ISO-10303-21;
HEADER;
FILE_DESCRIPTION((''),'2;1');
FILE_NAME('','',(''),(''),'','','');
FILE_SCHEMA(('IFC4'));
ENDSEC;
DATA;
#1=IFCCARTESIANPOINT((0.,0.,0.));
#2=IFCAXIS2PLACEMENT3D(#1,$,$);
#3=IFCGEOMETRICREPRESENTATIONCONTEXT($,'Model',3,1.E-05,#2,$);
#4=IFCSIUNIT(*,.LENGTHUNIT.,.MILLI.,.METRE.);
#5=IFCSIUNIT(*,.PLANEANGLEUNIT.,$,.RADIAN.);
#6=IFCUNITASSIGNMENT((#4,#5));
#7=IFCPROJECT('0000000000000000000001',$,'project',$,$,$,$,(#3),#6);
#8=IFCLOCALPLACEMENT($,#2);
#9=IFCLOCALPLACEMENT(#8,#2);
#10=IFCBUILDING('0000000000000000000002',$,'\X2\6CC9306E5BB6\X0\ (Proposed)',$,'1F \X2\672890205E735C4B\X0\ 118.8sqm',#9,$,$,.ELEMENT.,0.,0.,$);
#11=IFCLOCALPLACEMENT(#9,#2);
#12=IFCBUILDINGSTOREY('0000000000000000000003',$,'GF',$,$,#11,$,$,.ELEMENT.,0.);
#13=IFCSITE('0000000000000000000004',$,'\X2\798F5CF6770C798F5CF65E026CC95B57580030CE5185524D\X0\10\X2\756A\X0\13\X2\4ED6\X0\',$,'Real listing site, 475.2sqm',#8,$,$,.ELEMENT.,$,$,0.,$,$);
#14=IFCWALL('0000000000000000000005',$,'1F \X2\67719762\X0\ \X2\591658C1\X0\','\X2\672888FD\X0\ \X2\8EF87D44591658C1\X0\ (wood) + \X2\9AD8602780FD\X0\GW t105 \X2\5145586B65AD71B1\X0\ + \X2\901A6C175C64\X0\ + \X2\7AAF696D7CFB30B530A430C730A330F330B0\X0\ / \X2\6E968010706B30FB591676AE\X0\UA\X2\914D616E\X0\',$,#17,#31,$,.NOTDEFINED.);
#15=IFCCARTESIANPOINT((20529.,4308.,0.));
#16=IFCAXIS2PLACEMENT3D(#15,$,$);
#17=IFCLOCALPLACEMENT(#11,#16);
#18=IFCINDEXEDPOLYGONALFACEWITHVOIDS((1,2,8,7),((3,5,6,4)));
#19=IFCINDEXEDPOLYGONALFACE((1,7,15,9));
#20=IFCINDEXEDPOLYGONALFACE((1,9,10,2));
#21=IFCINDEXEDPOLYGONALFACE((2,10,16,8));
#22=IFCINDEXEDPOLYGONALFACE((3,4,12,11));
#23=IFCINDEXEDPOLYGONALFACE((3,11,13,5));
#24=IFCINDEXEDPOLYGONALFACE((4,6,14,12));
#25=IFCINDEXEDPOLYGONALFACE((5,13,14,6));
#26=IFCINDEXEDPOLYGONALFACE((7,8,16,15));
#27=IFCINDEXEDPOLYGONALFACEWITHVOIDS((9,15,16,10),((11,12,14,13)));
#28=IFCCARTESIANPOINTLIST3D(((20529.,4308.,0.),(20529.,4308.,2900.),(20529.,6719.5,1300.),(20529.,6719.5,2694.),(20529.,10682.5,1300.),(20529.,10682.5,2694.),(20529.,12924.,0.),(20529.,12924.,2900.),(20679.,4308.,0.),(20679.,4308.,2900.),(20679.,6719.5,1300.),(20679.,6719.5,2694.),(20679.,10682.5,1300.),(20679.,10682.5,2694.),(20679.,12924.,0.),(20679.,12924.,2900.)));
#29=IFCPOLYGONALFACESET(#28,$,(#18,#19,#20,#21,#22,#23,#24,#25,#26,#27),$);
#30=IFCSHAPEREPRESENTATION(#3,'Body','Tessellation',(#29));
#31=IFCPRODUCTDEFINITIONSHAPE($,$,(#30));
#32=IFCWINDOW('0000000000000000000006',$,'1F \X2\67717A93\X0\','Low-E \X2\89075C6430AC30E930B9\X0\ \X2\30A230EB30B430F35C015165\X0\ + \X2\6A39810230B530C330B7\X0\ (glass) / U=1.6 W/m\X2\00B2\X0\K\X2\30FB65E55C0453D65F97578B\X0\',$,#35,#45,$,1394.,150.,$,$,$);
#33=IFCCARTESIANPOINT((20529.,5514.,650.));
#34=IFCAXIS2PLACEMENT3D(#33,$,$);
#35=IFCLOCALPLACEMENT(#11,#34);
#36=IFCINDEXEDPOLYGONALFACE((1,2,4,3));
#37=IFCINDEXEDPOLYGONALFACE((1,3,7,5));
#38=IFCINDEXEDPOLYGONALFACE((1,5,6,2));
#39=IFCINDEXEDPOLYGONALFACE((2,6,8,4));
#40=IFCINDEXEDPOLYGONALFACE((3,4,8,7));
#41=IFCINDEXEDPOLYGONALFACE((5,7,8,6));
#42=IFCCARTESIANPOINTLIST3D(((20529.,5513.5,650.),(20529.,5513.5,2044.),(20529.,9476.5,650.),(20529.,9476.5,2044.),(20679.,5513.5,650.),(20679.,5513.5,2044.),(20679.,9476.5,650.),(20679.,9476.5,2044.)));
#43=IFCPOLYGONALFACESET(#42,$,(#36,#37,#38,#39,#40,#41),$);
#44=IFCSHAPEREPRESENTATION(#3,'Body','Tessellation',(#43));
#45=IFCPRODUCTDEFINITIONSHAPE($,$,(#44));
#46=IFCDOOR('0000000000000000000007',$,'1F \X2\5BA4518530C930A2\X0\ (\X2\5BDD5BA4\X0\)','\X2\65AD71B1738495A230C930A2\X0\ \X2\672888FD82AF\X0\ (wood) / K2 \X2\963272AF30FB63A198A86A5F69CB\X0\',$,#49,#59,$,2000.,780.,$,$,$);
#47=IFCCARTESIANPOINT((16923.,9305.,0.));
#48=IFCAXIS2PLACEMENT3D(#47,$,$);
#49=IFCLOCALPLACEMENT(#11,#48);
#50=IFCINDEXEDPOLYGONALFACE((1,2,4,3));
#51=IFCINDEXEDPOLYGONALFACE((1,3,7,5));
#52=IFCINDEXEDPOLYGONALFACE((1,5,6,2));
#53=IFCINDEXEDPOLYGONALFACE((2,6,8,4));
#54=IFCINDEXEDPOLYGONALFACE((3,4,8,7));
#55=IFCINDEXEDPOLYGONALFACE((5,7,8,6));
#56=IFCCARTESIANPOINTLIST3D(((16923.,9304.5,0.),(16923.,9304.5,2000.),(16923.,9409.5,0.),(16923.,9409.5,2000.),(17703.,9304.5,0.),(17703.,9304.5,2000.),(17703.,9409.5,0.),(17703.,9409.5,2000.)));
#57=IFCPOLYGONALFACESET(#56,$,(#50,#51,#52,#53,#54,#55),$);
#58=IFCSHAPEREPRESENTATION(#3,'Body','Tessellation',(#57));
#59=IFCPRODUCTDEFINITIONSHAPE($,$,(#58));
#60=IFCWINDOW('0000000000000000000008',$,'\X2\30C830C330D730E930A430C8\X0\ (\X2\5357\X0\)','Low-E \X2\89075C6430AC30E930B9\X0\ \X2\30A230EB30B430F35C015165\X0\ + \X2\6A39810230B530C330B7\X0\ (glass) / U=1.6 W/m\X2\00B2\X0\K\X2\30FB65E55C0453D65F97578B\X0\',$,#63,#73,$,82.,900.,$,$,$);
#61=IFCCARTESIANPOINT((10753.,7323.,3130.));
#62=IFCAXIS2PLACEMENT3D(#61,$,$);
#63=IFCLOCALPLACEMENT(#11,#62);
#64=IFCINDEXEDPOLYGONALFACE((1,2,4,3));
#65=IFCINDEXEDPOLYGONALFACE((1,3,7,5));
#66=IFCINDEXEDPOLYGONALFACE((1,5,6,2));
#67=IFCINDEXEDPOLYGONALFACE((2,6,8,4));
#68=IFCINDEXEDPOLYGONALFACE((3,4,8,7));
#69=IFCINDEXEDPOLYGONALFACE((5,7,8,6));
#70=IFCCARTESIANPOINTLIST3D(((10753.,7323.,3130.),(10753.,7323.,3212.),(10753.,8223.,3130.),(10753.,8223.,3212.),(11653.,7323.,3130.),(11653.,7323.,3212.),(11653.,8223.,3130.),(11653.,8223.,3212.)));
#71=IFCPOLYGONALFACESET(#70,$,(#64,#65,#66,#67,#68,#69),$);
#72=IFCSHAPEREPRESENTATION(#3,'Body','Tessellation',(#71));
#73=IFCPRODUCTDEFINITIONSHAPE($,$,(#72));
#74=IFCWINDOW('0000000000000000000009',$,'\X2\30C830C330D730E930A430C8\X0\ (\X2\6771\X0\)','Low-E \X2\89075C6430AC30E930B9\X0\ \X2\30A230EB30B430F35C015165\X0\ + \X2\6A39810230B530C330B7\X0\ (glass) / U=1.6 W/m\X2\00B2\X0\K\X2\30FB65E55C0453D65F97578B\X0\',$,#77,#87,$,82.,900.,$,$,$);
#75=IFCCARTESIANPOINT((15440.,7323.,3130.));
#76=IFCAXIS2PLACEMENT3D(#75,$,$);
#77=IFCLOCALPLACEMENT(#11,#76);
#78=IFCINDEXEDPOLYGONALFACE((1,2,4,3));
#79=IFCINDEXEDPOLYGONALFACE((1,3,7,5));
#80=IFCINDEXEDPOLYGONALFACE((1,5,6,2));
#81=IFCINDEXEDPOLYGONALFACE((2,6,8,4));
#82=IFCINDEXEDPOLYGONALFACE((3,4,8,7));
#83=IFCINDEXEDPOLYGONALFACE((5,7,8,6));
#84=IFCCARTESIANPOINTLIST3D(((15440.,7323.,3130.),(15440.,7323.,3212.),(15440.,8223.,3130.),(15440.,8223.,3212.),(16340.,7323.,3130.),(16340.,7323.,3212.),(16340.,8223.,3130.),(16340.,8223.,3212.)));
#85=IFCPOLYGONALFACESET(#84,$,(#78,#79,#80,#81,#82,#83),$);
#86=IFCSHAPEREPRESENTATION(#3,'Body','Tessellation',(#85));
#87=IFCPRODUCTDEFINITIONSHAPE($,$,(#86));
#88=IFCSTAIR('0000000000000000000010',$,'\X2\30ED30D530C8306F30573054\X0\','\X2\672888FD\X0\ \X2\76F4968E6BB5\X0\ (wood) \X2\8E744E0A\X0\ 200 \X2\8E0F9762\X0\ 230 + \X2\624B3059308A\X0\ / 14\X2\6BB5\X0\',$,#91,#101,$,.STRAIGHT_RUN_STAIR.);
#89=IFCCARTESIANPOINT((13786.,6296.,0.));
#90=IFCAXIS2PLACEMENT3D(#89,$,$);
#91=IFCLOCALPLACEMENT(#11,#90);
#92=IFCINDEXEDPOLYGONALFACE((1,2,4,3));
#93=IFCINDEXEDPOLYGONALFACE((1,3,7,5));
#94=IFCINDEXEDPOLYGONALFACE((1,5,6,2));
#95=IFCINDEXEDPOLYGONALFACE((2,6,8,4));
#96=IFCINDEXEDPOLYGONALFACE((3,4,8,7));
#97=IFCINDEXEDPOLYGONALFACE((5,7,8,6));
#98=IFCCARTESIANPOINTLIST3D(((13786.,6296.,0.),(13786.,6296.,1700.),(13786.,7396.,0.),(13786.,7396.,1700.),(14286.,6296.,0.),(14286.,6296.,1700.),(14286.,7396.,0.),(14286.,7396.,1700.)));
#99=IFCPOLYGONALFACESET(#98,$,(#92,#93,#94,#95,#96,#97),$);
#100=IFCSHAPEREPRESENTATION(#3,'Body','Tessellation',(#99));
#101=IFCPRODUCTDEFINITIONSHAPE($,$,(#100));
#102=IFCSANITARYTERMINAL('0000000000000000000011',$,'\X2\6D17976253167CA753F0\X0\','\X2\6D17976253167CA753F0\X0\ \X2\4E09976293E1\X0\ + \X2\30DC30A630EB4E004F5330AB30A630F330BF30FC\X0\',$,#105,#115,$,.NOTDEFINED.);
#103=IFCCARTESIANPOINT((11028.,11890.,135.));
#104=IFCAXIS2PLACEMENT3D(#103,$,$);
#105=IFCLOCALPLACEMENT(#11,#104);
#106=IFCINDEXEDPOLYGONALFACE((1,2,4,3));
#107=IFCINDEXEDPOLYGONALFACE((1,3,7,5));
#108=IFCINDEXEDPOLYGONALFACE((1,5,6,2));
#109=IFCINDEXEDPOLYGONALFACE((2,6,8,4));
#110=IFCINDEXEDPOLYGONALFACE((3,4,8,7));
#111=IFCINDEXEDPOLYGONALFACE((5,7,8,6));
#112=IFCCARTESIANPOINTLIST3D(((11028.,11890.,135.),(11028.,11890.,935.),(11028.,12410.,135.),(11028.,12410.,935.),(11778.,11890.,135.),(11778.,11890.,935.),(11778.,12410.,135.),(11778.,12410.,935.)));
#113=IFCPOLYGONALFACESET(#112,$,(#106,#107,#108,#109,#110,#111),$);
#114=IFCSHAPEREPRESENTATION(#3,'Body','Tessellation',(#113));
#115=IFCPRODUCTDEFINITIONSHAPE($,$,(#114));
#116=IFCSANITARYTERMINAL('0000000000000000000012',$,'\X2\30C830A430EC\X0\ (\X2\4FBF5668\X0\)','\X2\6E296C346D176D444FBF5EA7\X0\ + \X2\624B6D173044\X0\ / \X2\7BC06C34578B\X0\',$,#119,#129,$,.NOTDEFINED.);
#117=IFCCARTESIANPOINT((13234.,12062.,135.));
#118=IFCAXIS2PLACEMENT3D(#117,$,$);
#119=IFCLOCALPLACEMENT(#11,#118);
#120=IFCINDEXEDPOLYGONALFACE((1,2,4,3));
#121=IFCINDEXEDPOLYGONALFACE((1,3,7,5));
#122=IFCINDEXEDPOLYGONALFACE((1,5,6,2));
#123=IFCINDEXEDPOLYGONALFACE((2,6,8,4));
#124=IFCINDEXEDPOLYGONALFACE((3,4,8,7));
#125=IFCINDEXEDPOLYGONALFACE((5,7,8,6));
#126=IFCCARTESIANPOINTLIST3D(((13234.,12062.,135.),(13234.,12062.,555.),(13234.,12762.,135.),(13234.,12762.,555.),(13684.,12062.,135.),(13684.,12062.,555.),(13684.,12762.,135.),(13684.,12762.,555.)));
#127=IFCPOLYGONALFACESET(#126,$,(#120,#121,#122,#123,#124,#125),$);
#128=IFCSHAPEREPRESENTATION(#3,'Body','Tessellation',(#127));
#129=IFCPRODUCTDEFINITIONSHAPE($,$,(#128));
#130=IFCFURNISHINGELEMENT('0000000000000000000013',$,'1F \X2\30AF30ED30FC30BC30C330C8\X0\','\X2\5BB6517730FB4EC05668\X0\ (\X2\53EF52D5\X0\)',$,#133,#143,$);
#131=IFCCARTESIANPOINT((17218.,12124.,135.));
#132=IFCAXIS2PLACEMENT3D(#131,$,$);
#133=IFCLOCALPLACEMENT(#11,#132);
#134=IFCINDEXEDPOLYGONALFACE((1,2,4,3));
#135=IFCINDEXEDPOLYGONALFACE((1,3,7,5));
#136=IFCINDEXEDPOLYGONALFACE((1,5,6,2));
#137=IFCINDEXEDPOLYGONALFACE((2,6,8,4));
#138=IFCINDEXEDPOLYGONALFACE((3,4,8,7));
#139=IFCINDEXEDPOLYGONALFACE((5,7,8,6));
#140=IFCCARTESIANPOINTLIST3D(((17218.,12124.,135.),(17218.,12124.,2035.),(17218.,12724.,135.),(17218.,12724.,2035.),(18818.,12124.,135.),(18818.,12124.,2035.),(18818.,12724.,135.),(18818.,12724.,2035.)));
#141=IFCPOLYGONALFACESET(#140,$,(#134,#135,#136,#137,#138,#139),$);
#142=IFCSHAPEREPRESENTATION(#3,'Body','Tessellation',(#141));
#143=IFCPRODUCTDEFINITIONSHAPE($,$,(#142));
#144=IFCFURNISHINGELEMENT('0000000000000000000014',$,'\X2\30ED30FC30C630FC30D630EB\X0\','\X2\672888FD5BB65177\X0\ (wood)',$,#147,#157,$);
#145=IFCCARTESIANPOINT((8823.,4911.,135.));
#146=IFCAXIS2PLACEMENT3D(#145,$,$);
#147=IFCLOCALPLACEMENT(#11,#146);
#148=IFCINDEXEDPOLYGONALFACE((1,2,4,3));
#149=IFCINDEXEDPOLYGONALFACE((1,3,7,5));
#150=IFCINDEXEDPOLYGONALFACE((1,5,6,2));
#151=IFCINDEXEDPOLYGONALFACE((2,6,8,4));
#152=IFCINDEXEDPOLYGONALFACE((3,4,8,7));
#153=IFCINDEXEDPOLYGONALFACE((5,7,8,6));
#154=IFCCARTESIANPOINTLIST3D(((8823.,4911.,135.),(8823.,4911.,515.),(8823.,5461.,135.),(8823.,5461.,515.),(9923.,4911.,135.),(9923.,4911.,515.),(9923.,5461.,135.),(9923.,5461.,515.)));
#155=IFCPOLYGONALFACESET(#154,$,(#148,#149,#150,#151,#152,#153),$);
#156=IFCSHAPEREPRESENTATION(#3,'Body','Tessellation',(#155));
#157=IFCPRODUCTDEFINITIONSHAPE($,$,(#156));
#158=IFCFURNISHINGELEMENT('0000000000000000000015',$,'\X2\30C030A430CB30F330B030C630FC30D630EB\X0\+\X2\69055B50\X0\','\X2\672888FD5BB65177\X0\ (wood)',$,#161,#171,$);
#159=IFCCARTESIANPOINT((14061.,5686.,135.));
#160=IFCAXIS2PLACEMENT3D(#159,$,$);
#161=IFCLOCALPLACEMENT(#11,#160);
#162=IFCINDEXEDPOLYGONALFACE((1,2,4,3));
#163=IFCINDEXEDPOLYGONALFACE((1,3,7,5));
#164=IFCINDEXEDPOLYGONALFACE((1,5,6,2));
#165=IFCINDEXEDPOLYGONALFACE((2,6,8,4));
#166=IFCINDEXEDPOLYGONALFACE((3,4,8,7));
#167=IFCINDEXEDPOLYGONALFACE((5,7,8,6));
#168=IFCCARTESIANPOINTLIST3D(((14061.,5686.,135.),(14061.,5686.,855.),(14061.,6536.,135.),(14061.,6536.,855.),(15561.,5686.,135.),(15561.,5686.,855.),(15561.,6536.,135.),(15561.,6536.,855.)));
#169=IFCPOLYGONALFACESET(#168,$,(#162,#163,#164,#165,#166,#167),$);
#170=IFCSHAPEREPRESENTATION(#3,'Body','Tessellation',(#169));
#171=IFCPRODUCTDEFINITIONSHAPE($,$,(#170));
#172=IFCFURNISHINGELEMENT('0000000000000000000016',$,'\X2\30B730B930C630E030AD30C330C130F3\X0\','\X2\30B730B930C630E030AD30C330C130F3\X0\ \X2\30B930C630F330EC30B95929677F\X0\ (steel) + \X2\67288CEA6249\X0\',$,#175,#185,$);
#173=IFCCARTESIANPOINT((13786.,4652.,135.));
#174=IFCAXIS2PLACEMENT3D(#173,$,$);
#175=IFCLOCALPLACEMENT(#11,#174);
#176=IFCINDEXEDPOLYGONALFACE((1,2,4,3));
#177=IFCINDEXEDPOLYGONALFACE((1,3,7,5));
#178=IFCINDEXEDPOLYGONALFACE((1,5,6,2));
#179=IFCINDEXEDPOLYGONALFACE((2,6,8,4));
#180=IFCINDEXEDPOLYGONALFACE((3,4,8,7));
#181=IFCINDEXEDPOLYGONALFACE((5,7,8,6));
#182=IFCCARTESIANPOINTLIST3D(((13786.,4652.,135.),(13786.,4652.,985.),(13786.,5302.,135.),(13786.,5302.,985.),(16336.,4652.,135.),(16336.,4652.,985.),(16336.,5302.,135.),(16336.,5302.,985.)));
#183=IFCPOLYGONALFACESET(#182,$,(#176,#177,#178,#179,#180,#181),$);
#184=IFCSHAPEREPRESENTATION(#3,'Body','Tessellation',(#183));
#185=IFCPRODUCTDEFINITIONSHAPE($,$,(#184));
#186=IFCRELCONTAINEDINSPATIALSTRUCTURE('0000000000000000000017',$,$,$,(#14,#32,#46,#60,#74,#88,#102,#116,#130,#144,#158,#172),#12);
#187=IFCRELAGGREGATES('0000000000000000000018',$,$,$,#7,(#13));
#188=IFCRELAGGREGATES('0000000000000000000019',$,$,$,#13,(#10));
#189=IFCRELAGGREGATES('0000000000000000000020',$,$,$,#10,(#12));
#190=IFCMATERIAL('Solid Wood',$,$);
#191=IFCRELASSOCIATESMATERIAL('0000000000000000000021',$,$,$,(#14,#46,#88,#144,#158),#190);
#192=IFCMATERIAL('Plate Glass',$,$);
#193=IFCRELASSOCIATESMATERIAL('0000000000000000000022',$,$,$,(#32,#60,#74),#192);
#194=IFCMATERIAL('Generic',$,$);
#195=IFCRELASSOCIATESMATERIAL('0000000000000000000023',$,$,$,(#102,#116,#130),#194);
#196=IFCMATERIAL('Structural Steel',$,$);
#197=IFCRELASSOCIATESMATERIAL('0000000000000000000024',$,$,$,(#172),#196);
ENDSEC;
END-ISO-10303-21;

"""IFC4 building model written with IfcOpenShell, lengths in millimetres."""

from ifc_helpers import new_model, si_unit, frame, frame_2d, origin, place, context, project, spatial, rectangle, extrude, material, element, fill, save


model = new_model("IFC4")

# Units and contexts
model_context = context("Model", 3, precision=1e-05, world=origin())
ifc_project = project(units=[si_unit("LENGTHUNIT", "METRE", prefix="MILLI"), si_unit("PLANEANGLEUNIT", "RADIAN")], contexts=[model_context])

# Site, building, storey
site_placement = place(None, origin())
site = spatial("IfcSite", under=ifc_project, at=site_placement, Name="福島県福島市泉字堀ノ内前10番13他", ObjectType="Real listing site, 475.2sqm", CompositionType="ELEMENT", RefElevation=0.0)
building_placement = place(site_placement, origin())
building = spatial("IfcBuilding", under=site, at=building_placement, Name="泉の家 (Proposed)", ObjectType="1F 木造平屋 118.8sqm", CompositionType="ELEMENT", ElevationOfRefHeight=0.0, ElevationOfTerrain=0.0)
storey_placement = place(building_placement, origin())
storey = spatial("IfcBuildingStorey", under=building, at=storey_placement, Name="GF", CompositionType="ELEMENT", Elevation=0.0)

# Wall, opening, window
ifc_material_1 = material(Name="Solid Wood")
wall_1_placement = place(storey_placement, frame((20529.0, 4308.0, 0.0)))
wall_1 = element("IfcWall", 1, at=wall_1_placement, inside=storey, material=ifc_material_1, Name="1F 東面 外壁", Description="木製 軸組外壁 (wood) + 高性能GW t105 充填断熱 + 通気層 + 窯業系サイディング / 準耐火・外皮UA配慮", PredefinedType="NOTDEFINED", context=model_context, shape_type="SweptSolid", body=[
    extrude(rectangle(XDim=150.0, YDim=8616.0, at=frame_2d((75.0, 4308.0))), frame((20529.0, 4308.0, 0.0)), (0.0, 0.0, 1.0), 2900.0),
])
opening_placement = place(storey_placement, frame((20529.0, 5514.0, 650.0)))
opening = element("IfcOpeningElement", 2, at=opening_placement, cuts=wall_1, PredefinedType="NOTDEFINED", context=model_context, shape_type="SweptSolid", body=[
    extrude(rectangle(XDim=150.0, YDim=3963.0, at=frame_2d((75.0, 1981.0))), frame((20529.0, 5514.0, 650.0)), (0.0, 0.0, 1.0), 1394.0),
])
ifc_material_2 = material(Name="Plate Glass")
window_1_placement = place(storey_placement, frame((20529.0, 5514.0, 650.0)))
window_1 = element("IfcWindow", 3, at=window_1_placement, inside=storey, material=ifc_material_2, Name="1F 東窓", Description="Low-E 複層ガラス アルゴン封入 + 樹脂サッシ (glass) / U=1.6 W/m²K・日射取得型", OverallHeight=1394.0, OverallWidth=150.0, context=model_context, shape_type="SweptSolid", body=[
    extrude(rectangle(XDim=150.0, YDim=3963.0, at=frame_2d((75.0, 1981.0))), frame((20529.0, 5514.0, 650.0)), (0.0, 0.0, 1.0), 1394.0),
])
fill(opening, window_1)

# Door
door_placement = place(storey_placement, frame((16923.0, 9305.0, 0.0)))
element("IfcDoor", 4, at=door_placement, inside=storey, material=ifc_material_1, Name="1F 室内ドア (寝室)", Description="断熱玄関ドア 木製芯 (wood) / K2 防犯・採風機構", OverallHeight=2000.0, OverallWidth=780.0, context=model_context, shape_type="SweptSolid", body=[
    extrude(rectangle(XDim=780.0, YDim=105.0, at=frame_2d((390.0, 52.0))), frame((16923.0, 9305.0, 0.0)), (0.0, 0.0, 1.0), 2000.0),
])

# Windows
window_2_placement = place(storey_placement, frame((10753.0, 7323.0, 3130.0)))
element("IfcWindow", 5, at=window_2_placement, inside=storey, material=ifc_material_2, Name="トップライト (南)", Description="Low-E 複層ガラス アルゴン封入 + 樹脂サッシ (glass) / U=1.6 W/m²K・日射取得型", OverallHeight=82.0, OverallWidth=900.0, context=model_context, shape_type="SweptSolid", body=[
    extrude(rectangle(XDim=900.0, YDim=900.0, at=frame_2d((450.0, 450.0))), frame((10753.0, 7323.0, 3130.0)), (0.0, 0.0, 1.0), 82.0),
])
window_3_placement = place(storey_placement, frame((15440.0, 7323.0, 3130.0)))
element("IfcWindow", 6, at=window_3_placement, inside=storey, material=ifc_material_2, Name="トップライト (東)", Description="Low-E 複層ガラス アルゴン封入 + 樹脂サッシ (glass) / U=1.6 W/m²K・日射取得型", OverallHeight=82.0, OverallWidth=900.0, context=model_context, shape_type="SweptSolid", body=[
    extrude(rectangle(XDim=900.0, YDim=900.0, at=frame_2d((450.0, 450.0))), frame((15440.0, 7323.0, 3130.0)), (0.0, 0.0, 1.0), 82.0),
])

# Stair
stair_placement = place(storey_placement, frame((13786.0, 6296.0, 0.0)))
element("IfcStair", 7, at=stair_placement, inside=storey, material=ifc_material_1, Name="ロフトはしご", Description="木製 直階段 (wood) 蹴上 200 踏面 230 + 手すり / 14段", PredefinedType="STRAIGHT_RUN_STAIR", context=model_context, shape_type="SweptSolid", body=[
    extrude(rectangle(XDim=500.0, YDim=1100.0, at=frame_2d((250.0, 550.0))), frame((13786.0, 6296.0, 0.0)), (0.0, 0.0, 1.0), 1700.0),
])

# Sanitary terminals
ifc_material_3 = material(Name="Generic")
sanitary_terminal_1_placement = place(storey_placement, frame((11028.0, 11890.0, 135.0)))
element("IfcSanitaryTerminal", 8, at=sanitary_terminal_1_placement, inside=storey, material=ifc_material_3, Name="洗面化粧台", Description="洗面化粧台 三面鏡 + ボウル一体カウンター", PredefinedType="NOTDEFINED", context=model_context, shape_type="SweptSolid", body=[
    extrude(rectangle(XDim=750.0, YDim=520.0, at=frame_2d((375.0, 260.0))), frame((11028.0, 11890.0, 135.0)), (0.0, 0.0, 1.0), 800.0),
])
sanitary_terminal_2_placement = place(storey_placement, frame((13234.0, 12062.0, 135.0)))
element("IfcSanitaryTerminal", 9, at=sanitary_terminal_2_placement, inside=storey, material=ifc_material_3, Name="トイレ (便器)", Description="温水洗浄便座 + 手洗い / 節水型", PredefinedType="NOTDEFINED", context=model_context, shape_type="SweptSolid", body=[
    extrude(rectangle(XDim=450.0, YDim=700.0, at=frame_2d((225.0, 350.0))), frame((13234.0, 12062.0, 135.0)), (0.0, 0.0, 1.0), 420.0),
])

# Furnishing elements
furnishing_1_placement = place(storey_placement, frame((17218.0, 12124.0, 135.0)))
element("IfcFurnishingElement", 10, at=furnishing_1_placement, inside=storey, material=ifc_material_3, Name="1F クローゼット", Description="家具・什器 (可動)", context=model_context, shape_type="SweptSolid", body=[
    extrude(rectangle(XDim=1600.0, YDim=600.0, at=frame_2d((800.0, 300.0))), frame((17218.0, 12124.0, 135.0)), (0.0, 0.0, 1.0), 1900.0),
])
furnishing_2_placement = place(storey_placement, frame((8823.0, 4911.0, 135.0)))
element("IfcFurnishingElement", 11, at=furnishing_2_placement, inside=storey, material=ifc_material_1, Name="ローテーブル", Description="木製家具 (wood)", context=model_context, shape_type="SweptSolid", body=[
    extrude(rectangle(XDim=1100.0, YDim=550.0, at=frame_2d((550.0, 275.0))), frame((8823.0, 4911.0, 135.0)), (0.0, 0.0, 1.0), 380.0),
])
furnishing_3_placement = place(storey_placement, frame((14061.0, 5686.0, 135.0)))
element("IfcFurnishingElement", 12, at=furnishing_3_placement, inside=storey, material=ifc_material_1, Name="ダイニングテーブル+椅子", Description="木製家具 (wood)", context=model_context, shape_type="SweptSolid", body=[
    extrude(rectangle(XDim=1500.0, YDim=850.0, at=frame_2d((750.0, 425.0))), frame((14061.0, 5686.0, 135.0)), (0.0, 0.0, 1.0), 720.0),
])
ifc_material_4 = material(Name="Structural Steel")
furnishing_4_placement = place(storey_placement, frame((13786.0, 4652.0, 135.0)))
element("IfcFurnishingElement", 13, at=furnishing_4_placement, inside=storey, material=ifc_material_4, Name="システムキッチン", Description="システムキッチン ステンレス天板 (steel) + 木質扉", context=model_context, shape_type="SweptSolid", body=[
    extrude(rectangle(XDim=2550.0, YDim=650.0, at=frame_2d((1275.0, 325.0))), frame((13786.0, 4652.0, 135.0)), (0.0, 0.0, 1.0), 850.0),
])

save(model, "model.ifc")
